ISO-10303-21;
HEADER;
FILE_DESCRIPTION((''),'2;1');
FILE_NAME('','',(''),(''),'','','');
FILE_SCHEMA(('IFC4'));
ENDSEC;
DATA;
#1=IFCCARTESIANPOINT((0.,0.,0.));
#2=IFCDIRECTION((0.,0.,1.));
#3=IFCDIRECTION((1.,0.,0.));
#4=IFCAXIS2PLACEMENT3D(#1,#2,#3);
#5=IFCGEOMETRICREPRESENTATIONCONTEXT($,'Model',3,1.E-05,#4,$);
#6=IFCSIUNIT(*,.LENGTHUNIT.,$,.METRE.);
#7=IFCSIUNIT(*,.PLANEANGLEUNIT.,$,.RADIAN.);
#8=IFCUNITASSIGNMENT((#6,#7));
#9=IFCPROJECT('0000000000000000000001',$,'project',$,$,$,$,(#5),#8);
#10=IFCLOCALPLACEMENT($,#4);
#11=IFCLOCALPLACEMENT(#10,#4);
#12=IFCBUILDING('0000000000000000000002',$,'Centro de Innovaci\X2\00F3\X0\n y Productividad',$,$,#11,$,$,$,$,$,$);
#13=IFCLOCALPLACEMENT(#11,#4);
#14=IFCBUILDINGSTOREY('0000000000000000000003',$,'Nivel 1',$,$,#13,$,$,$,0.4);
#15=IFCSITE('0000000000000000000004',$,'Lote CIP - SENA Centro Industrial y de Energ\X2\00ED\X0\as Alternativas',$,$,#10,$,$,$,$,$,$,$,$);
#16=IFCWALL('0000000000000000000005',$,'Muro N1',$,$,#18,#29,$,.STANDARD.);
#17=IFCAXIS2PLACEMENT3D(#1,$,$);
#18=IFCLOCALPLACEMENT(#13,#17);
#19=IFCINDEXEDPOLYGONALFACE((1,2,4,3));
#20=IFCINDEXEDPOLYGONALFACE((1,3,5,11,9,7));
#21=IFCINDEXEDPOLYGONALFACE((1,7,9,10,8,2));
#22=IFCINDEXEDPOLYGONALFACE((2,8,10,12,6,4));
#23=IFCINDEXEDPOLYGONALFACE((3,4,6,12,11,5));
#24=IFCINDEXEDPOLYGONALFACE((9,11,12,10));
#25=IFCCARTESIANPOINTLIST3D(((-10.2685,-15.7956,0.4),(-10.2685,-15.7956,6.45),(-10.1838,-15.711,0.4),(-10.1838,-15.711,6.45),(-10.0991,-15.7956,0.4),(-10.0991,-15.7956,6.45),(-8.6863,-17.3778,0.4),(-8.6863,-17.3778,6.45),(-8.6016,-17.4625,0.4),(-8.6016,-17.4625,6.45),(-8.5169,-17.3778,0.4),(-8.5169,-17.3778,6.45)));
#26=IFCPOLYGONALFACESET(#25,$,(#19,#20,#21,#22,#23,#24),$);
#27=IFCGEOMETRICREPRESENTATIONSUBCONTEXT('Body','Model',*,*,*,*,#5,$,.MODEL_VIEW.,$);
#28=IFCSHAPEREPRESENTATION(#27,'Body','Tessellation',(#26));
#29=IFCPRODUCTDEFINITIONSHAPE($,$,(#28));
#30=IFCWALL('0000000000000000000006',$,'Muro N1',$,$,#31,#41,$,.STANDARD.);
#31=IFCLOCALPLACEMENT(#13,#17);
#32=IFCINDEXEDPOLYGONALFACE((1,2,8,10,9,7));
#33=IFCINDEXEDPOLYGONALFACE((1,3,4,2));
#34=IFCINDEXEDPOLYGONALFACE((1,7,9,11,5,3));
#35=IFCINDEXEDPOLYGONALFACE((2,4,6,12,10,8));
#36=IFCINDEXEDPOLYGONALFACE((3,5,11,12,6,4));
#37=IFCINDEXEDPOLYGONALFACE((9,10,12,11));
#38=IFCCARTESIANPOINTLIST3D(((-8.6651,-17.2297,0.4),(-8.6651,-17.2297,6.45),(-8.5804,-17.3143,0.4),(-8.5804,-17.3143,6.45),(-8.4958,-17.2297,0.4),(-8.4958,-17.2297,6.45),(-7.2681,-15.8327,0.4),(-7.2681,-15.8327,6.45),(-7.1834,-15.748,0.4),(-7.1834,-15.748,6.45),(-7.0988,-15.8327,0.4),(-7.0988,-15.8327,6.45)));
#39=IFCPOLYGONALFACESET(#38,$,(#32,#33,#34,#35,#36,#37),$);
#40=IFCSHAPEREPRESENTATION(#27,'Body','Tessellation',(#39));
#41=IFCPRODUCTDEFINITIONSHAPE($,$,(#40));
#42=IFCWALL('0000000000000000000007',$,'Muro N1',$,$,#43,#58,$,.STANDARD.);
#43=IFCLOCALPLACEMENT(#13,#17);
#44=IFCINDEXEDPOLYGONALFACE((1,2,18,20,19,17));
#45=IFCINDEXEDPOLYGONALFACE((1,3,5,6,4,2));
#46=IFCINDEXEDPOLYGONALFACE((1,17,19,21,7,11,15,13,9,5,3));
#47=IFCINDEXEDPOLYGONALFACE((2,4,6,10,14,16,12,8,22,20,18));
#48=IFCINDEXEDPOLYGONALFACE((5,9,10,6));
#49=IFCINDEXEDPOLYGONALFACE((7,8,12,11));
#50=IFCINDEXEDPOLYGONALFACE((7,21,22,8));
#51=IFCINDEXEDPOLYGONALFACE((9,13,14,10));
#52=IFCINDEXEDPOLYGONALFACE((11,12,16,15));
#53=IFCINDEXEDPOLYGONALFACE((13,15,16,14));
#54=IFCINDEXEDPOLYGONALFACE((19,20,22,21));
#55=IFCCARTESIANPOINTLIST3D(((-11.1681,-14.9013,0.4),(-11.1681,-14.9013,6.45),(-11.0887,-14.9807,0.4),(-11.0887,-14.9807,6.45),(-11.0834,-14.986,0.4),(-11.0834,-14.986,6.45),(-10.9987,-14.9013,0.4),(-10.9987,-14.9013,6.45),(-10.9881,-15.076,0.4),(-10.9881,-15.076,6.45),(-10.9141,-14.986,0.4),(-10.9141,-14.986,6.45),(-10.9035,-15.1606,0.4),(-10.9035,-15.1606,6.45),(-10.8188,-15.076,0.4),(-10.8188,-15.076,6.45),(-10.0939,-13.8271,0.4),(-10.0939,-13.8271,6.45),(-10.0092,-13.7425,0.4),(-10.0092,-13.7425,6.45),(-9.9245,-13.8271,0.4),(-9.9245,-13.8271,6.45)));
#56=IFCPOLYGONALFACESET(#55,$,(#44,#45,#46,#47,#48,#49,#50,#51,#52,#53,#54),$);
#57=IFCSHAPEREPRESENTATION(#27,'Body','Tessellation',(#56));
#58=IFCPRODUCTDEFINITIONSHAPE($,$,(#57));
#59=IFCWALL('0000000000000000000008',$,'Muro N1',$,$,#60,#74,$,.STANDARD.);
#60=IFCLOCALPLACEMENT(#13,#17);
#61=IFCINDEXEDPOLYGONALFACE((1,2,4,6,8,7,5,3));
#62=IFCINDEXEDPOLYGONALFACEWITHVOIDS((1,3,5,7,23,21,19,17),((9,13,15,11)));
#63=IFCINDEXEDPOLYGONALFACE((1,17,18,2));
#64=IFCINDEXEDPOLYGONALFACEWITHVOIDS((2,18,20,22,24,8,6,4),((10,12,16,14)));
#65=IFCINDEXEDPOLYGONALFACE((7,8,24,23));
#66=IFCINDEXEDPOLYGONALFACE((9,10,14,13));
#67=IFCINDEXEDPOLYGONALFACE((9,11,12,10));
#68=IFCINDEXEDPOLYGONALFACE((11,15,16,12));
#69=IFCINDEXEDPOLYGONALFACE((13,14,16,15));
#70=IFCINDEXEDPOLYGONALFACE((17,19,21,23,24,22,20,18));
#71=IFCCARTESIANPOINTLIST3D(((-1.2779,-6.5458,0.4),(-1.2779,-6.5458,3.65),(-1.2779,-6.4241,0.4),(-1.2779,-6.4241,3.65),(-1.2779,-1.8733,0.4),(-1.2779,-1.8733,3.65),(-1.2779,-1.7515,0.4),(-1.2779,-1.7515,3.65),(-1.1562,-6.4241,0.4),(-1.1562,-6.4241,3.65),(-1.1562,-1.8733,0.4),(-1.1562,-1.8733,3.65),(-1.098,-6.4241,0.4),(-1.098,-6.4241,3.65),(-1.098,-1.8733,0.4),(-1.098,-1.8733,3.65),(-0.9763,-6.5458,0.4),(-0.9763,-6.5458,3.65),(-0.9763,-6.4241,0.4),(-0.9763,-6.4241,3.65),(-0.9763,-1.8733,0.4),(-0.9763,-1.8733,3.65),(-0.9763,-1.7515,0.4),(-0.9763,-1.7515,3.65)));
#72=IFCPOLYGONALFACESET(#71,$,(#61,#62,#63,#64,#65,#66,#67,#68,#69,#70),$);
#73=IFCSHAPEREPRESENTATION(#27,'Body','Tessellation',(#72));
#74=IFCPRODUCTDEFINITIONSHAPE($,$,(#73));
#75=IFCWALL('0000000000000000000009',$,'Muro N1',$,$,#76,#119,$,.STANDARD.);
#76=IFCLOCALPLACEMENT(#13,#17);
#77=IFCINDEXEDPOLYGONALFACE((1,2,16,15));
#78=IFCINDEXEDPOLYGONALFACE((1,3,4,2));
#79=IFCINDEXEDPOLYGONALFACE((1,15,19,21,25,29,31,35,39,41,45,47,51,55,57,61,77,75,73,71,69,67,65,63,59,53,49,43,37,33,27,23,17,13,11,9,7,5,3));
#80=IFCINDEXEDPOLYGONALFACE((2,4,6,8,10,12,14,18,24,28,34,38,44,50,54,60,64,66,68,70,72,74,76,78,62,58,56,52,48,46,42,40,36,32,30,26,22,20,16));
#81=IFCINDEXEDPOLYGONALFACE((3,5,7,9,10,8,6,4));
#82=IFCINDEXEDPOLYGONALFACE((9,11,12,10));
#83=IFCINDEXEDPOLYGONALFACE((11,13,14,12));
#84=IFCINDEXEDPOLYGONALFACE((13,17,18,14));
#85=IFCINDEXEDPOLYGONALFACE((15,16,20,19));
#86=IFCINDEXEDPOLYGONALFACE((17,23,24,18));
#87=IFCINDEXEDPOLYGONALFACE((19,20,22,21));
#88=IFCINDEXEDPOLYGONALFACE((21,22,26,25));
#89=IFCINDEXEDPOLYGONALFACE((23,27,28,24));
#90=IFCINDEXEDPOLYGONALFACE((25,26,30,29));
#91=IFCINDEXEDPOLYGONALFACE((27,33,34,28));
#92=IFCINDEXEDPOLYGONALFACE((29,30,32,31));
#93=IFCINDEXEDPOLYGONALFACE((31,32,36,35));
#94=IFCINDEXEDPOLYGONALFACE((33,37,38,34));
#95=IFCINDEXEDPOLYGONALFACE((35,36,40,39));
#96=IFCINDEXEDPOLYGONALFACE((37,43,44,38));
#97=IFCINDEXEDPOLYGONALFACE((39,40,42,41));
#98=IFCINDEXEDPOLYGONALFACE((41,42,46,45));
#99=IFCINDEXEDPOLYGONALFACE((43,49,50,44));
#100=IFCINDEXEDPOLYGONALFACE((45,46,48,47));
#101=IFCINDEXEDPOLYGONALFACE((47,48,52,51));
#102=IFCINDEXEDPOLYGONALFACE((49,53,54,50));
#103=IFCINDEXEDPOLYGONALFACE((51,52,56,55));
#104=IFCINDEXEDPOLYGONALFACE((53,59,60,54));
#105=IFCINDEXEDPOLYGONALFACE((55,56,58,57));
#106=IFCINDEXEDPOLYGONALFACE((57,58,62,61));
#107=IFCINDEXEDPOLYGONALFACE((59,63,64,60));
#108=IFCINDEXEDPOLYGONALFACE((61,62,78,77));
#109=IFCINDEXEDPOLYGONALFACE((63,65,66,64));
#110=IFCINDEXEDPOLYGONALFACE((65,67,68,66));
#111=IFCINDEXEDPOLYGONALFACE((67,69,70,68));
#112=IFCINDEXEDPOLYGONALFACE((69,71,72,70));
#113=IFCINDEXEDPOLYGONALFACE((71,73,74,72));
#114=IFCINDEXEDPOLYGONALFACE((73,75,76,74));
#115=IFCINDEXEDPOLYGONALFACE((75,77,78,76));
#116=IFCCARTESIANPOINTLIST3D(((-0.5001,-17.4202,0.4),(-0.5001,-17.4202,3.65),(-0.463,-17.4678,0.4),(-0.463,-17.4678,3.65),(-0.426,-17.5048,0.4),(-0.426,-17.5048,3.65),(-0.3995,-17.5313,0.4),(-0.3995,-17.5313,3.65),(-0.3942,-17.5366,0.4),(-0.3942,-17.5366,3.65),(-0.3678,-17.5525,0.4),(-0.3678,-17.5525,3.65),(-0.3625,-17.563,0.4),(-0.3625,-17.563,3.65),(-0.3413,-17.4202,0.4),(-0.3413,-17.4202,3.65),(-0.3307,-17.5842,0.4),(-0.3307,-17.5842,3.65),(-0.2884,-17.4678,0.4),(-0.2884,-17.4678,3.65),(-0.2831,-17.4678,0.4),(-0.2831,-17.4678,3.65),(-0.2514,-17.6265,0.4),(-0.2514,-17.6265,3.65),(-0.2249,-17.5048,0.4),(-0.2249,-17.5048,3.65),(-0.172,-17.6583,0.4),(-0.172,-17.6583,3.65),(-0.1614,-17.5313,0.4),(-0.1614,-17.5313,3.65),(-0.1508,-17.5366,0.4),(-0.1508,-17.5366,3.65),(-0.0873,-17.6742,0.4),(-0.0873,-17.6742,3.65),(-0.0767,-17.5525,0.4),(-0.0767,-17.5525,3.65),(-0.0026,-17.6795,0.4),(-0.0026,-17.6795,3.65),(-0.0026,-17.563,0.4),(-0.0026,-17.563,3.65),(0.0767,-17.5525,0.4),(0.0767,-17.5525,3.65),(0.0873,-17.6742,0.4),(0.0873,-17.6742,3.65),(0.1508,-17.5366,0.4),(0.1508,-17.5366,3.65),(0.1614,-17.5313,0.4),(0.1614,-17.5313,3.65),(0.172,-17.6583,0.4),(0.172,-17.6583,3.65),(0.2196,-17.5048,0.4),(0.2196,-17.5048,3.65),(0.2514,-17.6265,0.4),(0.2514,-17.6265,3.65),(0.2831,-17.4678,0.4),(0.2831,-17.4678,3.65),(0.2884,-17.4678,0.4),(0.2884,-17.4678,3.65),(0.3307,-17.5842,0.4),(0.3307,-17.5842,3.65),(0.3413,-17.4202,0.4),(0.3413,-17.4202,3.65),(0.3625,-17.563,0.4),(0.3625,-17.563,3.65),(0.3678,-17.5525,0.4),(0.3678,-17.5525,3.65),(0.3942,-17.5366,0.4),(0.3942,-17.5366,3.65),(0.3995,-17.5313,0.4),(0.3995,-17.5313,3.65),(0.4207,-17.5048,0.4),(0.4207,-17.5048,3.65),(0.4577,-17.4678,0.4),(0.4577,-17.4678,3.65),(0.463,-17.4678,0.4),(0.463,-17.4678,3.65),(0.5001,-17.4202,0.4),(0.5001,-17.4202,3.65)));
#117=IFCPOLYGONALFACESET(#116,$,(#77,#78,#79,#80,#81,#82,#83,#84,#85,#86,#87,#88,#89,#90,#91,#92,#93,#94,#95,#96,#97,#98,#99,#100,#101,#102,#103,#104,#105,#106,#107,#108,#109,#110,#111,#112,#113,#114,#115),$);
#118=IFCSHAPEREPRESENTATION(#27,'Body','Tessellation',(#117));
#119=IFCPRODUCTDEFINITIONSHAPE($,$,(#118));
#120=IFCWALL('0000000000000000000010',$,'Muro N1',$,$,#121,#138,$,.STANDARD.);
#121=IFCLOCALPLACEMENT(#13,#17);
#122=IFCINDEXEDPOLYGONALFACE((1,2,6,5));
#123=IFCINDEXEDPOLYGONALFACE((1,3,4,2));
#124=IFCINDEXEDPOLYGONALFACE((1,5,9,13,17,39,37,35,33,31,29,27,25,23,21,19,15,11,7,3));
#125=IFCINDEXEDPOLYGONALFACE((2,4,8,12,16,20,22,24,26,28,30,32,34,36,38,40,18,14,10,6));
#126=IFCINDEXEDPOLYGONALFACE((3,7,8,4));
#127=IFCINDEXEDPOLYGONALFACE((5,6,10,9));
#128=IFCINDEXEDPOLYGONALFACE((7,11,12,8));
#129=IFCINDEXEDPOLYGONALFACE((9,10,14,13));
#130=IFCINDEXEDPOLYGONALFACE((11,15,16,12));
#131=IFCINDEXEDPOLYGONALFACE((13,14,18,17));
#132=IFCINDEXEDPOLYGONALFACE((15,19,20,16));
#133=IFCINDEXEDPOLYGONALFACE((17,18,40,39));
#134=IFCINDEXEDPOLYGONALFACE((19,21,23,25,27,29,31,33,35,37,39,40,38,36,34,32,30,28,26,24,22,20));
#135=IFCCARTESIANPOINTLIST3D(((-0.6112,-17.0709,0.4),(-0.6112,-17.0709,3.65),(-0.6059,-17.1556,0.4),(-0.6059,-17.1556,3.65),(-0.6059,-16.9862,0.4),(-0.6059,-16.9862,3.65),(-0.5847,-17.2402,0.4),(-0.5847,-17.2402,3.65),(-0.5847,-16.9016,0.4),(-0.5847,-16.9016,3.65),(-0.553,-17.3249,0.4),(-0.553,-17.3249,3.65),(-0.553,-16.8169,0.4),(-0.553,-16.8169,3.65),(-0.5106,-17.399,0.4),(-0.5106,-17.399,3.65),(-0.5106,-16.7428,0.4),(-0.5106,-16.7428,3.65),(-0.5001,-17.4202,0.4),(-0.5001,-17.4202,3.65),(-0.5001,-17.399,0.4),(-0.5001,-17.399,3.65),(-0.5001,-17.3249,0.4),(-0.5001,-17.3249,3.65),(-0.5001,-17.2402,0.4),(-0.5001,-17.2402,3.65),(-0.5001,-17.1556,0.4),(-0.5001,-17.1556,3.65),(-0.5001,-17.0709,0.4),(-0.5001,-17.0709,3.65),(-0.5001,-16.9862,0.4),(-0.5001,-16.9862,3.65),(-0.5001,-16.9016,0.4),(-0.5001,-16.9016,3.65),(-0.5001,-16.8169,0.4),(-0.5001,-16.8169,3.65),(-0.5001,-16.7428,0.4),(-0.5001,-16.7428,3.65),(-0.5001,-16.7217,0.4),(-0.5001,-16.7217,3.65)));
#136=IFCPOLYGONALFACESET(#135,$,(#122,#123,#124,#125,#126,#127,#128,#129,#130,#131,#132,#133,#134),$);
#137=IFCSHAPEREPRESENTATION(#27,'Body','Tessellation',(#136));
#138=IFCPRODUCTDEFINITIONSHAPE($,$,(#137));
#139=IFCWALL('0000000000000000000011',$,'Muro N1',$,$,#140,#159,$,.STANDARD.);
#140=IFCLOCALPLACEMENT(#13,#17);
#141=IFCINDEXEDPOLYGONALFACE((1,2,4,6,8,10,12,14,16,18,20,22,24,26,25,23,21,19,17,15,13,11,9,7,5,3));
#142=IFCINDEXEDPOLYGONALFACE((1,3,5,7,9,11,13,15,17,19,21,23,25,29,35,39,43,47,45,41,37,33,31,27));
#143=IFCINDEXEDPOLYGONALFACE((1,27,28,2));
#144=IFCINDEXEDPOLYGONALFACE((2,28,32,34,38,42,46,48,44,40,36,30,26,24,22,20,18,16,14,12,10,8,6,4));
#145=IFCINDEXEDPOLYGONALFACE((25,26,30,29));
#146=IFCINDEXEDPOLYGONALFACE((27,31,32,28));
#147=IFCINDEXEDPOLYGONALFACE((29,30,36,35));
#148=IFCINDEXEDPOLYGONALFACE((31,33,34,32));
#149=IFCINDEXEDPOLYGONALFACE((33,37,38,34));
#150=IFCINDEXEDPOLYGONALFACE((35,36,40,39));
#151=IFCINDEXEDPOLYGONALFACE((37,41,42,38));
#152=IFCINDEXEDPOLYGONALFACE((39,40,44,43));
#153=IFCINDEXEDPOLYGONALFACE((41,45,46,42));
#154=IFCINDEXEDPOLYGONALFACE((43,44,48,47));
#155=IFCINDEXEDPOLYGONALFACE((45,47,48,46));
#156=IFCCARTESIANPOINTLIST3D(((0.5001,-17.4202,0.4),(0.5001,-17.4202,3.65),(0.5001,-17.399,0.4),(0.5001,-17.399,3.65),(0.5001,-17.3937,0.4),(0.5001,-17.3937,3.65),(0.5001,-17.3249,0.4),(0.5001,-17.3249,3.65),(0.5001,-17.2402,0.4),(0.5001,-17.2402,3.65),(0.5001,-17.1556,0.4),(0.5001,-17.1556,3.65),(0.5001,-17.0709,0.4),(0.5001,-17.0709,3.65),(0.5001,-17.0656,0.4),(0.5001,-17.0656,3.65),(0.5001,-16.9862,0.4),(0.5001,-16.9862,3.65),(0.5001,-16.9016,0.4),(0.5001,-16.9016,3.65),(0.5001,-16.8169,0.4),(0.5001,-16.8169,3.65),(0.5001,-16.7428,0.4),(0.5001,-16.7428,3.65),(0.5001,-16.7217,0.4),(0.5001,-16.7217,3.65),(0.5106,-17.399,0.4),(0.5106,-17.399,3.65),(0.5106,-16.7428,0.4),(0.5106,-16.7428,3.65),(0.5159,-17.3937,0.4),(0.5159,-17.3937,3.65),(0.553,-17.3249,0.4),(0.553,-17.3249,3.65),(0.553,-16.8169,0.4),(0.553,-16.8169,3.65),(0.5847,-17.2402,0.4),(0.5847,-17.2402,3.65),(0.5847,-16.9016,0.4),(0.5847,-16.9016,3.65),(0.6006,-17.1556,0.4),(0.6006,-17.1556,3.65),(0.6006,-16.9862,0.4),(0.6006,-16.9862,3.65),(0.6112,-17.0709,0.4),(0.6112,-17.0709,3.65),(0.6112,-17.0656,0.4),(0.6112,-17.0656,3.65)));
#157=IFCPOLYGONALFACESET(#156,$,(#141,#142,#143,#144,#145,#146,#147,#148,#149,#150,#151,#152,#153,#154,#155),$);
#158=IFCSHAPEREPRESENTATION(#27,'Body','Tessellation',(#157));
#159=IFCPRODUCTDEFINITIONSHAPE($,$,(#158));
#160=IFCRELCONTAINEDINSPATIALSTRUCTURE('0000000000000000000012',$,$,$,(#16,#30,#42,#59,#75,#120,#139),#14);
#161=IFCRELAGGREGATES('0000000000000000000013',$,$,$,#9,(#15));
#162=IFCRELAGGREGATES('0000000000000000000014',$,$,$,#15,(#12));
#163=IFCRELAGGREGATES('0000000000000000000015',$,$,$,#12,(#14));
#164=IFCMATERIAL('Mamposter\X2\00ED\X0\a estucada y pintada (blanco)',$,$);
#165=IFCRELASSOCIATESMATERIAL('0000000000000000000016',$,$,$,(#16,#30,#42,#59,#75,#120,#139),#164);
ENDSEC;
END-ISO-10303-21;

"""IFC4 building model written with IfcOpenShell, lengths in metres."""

from ifc_helpers import new_model, si_unit, frame, origin_with_axes, place, context, subcontext, project, spatial, polyline, outline, extrude, material, element, save


model = new_model("IFC4")

# Units and contexts
model_context = context("Model", 3, precision=1e-05, world=origin_with_axes())
body_context = subcontext(model_context, "Body", "Model", "MODEL_VIEW")
ifc_project = project(units=[si_unit("LENGTHUNIT", "METRE"), si_unit("PLANEANGLEUNIT", "RADIAN")], contexts=[model_context])

# Site, building, storey
site_placement = place(None, origin_with_axes())
site = spatial("IfcSite", under=ifc_project, at=site_placement, Name="Lote CIP - SENA Centro Industrial y de Energías Alternativas")
building_placement = place(site_placement, origin_with_axes())
building = spatial("IfcBuilding", under=site, at=building_placement, Name="Centro de Innovación y Productividad")
storey_placement = place(building_placement, origin_with_axes())
storey = spatial("IfcBuildingStorey", under=building, at=storey_placement, Name="Nivel 1", Elevation=0.4)

# Walls
ifc_material = material(Name="Mampostería estucada y pintada (blanco)")
wall_1_placement = place(storey_placement, origin_with_axes())
element("IfcWall", 1, at=wall_1_placement, inside=storey, material=ifc_material, Name="Muro N1", PredefinedType="STANDARD", context=body_context, shape_type="SweptSolid", body=[
    extrude(outline(polyline([(-10.1838, -15.711), (-10.0991, -15.7956), (-8.5169, -17.3778), (-8.6016, -17.4625), (-8.6863, -17.3778), (-10.2685, -15.7956), (-10.1838, -15.711)])), frame((0.0, 0.0, 0.4)), (0.0, 0.0, 1.0), 6.05),
])
wall_2_placement = place(storey_placement, origin_with_axes())
element("IfcWall", 2, at=wall_2_placement, inside=storey, material=ifc_material, Name="Muro N1", PredefinedType="STANDARD", context=body_context, shape_type="SweptSolid", body=[
    extrude(outline(polyline([(-7.1834, -15.748), (-7.0988, -15.8327), (-8.4958, -17.2297), (-8.5804, -17.3143), (-8.6651, -17.2297), (-7.2681, -15.8327), (-7.1834, -15.748)])), frame((0.0, 0.0, 0.4)), (0.0, 0.0, 1.0), 6.05),
])
wall_3_placement = place(storey_placement, origin_with_axes())
element("IfcWall", 3, at=wall_3_placement, inside=storey, material=ifc_material, Name="Muro N1", PredefinedType="STANDARD", context=body_context, shape_type="SweptSolid", body=[
    extrude(outline(polyline([(-10.9987, -14.9013), (-10.9141, -14.986), (-10.8188, -15.076), (-10.9035, -15.1606), (-10.9881, -15.076), (-11.0834, -14.986), (-11.0887, -14.9807), (-11.1681, -14.9013), (-10.0939, -13.8271), (-10.0092, -13.7425), (-9.9245, -13.8271), (-10.9987, -14.9013)])), frame((0.0, 0.0, 0.4)), (0.0, 0.0, 1.0), 6.05),
])
wall_4_placement = place(storey_placement, origin_with_axes())
element("IfcWall", 4, at=wall_4_placement, inside=storey, material=ifc_material, Name="Muro N1", PredefinedType="STANDARD", context=body_context, shape_type="SweptSolid", body=[
    extrude(outline(polyline([(-0.9763, -1.8733), (-0.9763, -6.4241), (-0.9763, -6.5458), (-1.2779, -6.5458), (-1.2779, -6.4241), (-1.2779, -1.8733), (-1.2779, -1.7515), (-0.9763, -1.7515), (-0.9763, -1.8733)]), holes=[polyline([(-1.1562, -6.4241), (-1.098, -6.4241), (-1.098, -1.8733), (-1.1562, -1.8733), (-1.1562, -6.4241)])]), frame((0.0, 0.0, 0.4)), (0.0, 0.0, 1.0), 3.25),
])
wall_5_placement = place(storey_placement, origin_with_axes())
element("IfcWall", 5, at=wall_5_placement, inside=storey, material=ifc_material, Name="Muro N1", PredefinedType="STANDARD", context=body_context, shape_type="SweptSolid", body=[
    extrude(outline(polyline([(-0.2514, -17.6265), (-0.3307, -17.5842), (-0.3625, -17.563), (-0.3678, -17.5525), (-0.3942, -17.5366), (-0.3995, -17.5313), (-0.426, -17.5048), (-0.463, -17.4678), (-0.5001, -17.4202), (-0.3413, -17.4202), (-0.2884, -17.4678), (-0.2831, -17.4678), (-0.2249, -17.5048), (-0.1614, -17.5313), (-0.1508, -17.5366), (-0.0767, -17.5525), (-0.0026, -17.563), (0.0767, -17.5525), (0.1508, -17.5366), (0.1614, -17.5313), (0.2196, -17.5048), (0.2831, -17.4678), (0.2884, -17.4678), (0.3413, -17.4202), (0.5001, -17.4202), (0.463, -17.4678), (0.4577, -17.4678), (0.4207, -17.5048), (0.3995, -17.5313), (0.3942, -17.5366), (0.3678, -17.5525), (0.3625, -17.563), (0.3307, -17.5842), (0.2514, -17.6265), (0.172, -17.6583), (0.0873, -17.6742), (-0.0026, -17.6795), (-0.0873, -17.6742), (-0.172, -17.6583), (-0.2514, -17.6265)])), frame((0.0, 0.0, 0.4)), (0.0, 0.0, 1.0), 3.25),
])
wall_6_placement = place(storey_placement, origin_with_axes())
element("IfcWall", 6, at=wall_6_placement, inside=storey, material=ifc_material, Name="Muro N1", PredefinedType="STANDARD", context=body_context, shape_type="SweptSolid", body=[
    extrude(outline(polyline([(-0.553, -16.8169), (-0.5106, -16.7428), (-0.5001, -16.7217), (-0.5001, -16.7428), (-0.5001, -16.8169), (-0.5001, -16.9016), (-0.5001, -16.9862), (-0.5001, -17.0709), (-0.5001, -17.1556), (-0.5001, -17.2402), (-0.5001, -17.3249), (-0.5001, -17.399), (-0.5001, -17.4202), (-0.5106, -17.399), (-0.553, -17.3249), (-0.5847, -17.2402), (-0.6059, -17.1556), (-0.6112, -17.0709), (-0.6059, -16.9862), (-0.5847, -16.9016), (-0.553, -16.8169)])), frame((0.0, 0.0, 0.4)), (0.0, 0.0, 1.0), 3.25),
])
wall_7_placement = place(storey_placement, origin_with_axes())
element("IfcWall", 7, at=wall_7_placement, inside=storey, material=ifc_material, Name="Muro N1", PredefinedType="STANDARD", context=body_context, shape_type="SweptSolid", body=[
    extrude(outline(polyline([(0.5001, -17.3249), (0.5001, -17.2402), (0.5001, -17.1556), (0.5001, -17.0709), (0.5001, -17.0656), (0.5001, -16.9862), (0.5001, -16.9016), (0.5001, -16.8169), (0.5001, -16.7428), (0.5001, -16.7217), (0.5106, -16.7428), (0.553, -16.8169), (0.5847, -16.9016), (0.6006, -16.9862), (0.6112, -17.0656), (0.6112, -17.0709), (0.6006, -17.1556), (0.5847, -17.2402), (0.553, -17.3249), (0.5159, -17.3937), (0.5106, -17.399), (0.5001, -17.4202), (0.5001, -17.399), (0.5001, -17.3937), (0.5001, -17.3249)])), frame((0.0, 0.0, 0.4)), (0.0, 0.0, 1.0), 3.25),
])

save(model, "model.ifc")
